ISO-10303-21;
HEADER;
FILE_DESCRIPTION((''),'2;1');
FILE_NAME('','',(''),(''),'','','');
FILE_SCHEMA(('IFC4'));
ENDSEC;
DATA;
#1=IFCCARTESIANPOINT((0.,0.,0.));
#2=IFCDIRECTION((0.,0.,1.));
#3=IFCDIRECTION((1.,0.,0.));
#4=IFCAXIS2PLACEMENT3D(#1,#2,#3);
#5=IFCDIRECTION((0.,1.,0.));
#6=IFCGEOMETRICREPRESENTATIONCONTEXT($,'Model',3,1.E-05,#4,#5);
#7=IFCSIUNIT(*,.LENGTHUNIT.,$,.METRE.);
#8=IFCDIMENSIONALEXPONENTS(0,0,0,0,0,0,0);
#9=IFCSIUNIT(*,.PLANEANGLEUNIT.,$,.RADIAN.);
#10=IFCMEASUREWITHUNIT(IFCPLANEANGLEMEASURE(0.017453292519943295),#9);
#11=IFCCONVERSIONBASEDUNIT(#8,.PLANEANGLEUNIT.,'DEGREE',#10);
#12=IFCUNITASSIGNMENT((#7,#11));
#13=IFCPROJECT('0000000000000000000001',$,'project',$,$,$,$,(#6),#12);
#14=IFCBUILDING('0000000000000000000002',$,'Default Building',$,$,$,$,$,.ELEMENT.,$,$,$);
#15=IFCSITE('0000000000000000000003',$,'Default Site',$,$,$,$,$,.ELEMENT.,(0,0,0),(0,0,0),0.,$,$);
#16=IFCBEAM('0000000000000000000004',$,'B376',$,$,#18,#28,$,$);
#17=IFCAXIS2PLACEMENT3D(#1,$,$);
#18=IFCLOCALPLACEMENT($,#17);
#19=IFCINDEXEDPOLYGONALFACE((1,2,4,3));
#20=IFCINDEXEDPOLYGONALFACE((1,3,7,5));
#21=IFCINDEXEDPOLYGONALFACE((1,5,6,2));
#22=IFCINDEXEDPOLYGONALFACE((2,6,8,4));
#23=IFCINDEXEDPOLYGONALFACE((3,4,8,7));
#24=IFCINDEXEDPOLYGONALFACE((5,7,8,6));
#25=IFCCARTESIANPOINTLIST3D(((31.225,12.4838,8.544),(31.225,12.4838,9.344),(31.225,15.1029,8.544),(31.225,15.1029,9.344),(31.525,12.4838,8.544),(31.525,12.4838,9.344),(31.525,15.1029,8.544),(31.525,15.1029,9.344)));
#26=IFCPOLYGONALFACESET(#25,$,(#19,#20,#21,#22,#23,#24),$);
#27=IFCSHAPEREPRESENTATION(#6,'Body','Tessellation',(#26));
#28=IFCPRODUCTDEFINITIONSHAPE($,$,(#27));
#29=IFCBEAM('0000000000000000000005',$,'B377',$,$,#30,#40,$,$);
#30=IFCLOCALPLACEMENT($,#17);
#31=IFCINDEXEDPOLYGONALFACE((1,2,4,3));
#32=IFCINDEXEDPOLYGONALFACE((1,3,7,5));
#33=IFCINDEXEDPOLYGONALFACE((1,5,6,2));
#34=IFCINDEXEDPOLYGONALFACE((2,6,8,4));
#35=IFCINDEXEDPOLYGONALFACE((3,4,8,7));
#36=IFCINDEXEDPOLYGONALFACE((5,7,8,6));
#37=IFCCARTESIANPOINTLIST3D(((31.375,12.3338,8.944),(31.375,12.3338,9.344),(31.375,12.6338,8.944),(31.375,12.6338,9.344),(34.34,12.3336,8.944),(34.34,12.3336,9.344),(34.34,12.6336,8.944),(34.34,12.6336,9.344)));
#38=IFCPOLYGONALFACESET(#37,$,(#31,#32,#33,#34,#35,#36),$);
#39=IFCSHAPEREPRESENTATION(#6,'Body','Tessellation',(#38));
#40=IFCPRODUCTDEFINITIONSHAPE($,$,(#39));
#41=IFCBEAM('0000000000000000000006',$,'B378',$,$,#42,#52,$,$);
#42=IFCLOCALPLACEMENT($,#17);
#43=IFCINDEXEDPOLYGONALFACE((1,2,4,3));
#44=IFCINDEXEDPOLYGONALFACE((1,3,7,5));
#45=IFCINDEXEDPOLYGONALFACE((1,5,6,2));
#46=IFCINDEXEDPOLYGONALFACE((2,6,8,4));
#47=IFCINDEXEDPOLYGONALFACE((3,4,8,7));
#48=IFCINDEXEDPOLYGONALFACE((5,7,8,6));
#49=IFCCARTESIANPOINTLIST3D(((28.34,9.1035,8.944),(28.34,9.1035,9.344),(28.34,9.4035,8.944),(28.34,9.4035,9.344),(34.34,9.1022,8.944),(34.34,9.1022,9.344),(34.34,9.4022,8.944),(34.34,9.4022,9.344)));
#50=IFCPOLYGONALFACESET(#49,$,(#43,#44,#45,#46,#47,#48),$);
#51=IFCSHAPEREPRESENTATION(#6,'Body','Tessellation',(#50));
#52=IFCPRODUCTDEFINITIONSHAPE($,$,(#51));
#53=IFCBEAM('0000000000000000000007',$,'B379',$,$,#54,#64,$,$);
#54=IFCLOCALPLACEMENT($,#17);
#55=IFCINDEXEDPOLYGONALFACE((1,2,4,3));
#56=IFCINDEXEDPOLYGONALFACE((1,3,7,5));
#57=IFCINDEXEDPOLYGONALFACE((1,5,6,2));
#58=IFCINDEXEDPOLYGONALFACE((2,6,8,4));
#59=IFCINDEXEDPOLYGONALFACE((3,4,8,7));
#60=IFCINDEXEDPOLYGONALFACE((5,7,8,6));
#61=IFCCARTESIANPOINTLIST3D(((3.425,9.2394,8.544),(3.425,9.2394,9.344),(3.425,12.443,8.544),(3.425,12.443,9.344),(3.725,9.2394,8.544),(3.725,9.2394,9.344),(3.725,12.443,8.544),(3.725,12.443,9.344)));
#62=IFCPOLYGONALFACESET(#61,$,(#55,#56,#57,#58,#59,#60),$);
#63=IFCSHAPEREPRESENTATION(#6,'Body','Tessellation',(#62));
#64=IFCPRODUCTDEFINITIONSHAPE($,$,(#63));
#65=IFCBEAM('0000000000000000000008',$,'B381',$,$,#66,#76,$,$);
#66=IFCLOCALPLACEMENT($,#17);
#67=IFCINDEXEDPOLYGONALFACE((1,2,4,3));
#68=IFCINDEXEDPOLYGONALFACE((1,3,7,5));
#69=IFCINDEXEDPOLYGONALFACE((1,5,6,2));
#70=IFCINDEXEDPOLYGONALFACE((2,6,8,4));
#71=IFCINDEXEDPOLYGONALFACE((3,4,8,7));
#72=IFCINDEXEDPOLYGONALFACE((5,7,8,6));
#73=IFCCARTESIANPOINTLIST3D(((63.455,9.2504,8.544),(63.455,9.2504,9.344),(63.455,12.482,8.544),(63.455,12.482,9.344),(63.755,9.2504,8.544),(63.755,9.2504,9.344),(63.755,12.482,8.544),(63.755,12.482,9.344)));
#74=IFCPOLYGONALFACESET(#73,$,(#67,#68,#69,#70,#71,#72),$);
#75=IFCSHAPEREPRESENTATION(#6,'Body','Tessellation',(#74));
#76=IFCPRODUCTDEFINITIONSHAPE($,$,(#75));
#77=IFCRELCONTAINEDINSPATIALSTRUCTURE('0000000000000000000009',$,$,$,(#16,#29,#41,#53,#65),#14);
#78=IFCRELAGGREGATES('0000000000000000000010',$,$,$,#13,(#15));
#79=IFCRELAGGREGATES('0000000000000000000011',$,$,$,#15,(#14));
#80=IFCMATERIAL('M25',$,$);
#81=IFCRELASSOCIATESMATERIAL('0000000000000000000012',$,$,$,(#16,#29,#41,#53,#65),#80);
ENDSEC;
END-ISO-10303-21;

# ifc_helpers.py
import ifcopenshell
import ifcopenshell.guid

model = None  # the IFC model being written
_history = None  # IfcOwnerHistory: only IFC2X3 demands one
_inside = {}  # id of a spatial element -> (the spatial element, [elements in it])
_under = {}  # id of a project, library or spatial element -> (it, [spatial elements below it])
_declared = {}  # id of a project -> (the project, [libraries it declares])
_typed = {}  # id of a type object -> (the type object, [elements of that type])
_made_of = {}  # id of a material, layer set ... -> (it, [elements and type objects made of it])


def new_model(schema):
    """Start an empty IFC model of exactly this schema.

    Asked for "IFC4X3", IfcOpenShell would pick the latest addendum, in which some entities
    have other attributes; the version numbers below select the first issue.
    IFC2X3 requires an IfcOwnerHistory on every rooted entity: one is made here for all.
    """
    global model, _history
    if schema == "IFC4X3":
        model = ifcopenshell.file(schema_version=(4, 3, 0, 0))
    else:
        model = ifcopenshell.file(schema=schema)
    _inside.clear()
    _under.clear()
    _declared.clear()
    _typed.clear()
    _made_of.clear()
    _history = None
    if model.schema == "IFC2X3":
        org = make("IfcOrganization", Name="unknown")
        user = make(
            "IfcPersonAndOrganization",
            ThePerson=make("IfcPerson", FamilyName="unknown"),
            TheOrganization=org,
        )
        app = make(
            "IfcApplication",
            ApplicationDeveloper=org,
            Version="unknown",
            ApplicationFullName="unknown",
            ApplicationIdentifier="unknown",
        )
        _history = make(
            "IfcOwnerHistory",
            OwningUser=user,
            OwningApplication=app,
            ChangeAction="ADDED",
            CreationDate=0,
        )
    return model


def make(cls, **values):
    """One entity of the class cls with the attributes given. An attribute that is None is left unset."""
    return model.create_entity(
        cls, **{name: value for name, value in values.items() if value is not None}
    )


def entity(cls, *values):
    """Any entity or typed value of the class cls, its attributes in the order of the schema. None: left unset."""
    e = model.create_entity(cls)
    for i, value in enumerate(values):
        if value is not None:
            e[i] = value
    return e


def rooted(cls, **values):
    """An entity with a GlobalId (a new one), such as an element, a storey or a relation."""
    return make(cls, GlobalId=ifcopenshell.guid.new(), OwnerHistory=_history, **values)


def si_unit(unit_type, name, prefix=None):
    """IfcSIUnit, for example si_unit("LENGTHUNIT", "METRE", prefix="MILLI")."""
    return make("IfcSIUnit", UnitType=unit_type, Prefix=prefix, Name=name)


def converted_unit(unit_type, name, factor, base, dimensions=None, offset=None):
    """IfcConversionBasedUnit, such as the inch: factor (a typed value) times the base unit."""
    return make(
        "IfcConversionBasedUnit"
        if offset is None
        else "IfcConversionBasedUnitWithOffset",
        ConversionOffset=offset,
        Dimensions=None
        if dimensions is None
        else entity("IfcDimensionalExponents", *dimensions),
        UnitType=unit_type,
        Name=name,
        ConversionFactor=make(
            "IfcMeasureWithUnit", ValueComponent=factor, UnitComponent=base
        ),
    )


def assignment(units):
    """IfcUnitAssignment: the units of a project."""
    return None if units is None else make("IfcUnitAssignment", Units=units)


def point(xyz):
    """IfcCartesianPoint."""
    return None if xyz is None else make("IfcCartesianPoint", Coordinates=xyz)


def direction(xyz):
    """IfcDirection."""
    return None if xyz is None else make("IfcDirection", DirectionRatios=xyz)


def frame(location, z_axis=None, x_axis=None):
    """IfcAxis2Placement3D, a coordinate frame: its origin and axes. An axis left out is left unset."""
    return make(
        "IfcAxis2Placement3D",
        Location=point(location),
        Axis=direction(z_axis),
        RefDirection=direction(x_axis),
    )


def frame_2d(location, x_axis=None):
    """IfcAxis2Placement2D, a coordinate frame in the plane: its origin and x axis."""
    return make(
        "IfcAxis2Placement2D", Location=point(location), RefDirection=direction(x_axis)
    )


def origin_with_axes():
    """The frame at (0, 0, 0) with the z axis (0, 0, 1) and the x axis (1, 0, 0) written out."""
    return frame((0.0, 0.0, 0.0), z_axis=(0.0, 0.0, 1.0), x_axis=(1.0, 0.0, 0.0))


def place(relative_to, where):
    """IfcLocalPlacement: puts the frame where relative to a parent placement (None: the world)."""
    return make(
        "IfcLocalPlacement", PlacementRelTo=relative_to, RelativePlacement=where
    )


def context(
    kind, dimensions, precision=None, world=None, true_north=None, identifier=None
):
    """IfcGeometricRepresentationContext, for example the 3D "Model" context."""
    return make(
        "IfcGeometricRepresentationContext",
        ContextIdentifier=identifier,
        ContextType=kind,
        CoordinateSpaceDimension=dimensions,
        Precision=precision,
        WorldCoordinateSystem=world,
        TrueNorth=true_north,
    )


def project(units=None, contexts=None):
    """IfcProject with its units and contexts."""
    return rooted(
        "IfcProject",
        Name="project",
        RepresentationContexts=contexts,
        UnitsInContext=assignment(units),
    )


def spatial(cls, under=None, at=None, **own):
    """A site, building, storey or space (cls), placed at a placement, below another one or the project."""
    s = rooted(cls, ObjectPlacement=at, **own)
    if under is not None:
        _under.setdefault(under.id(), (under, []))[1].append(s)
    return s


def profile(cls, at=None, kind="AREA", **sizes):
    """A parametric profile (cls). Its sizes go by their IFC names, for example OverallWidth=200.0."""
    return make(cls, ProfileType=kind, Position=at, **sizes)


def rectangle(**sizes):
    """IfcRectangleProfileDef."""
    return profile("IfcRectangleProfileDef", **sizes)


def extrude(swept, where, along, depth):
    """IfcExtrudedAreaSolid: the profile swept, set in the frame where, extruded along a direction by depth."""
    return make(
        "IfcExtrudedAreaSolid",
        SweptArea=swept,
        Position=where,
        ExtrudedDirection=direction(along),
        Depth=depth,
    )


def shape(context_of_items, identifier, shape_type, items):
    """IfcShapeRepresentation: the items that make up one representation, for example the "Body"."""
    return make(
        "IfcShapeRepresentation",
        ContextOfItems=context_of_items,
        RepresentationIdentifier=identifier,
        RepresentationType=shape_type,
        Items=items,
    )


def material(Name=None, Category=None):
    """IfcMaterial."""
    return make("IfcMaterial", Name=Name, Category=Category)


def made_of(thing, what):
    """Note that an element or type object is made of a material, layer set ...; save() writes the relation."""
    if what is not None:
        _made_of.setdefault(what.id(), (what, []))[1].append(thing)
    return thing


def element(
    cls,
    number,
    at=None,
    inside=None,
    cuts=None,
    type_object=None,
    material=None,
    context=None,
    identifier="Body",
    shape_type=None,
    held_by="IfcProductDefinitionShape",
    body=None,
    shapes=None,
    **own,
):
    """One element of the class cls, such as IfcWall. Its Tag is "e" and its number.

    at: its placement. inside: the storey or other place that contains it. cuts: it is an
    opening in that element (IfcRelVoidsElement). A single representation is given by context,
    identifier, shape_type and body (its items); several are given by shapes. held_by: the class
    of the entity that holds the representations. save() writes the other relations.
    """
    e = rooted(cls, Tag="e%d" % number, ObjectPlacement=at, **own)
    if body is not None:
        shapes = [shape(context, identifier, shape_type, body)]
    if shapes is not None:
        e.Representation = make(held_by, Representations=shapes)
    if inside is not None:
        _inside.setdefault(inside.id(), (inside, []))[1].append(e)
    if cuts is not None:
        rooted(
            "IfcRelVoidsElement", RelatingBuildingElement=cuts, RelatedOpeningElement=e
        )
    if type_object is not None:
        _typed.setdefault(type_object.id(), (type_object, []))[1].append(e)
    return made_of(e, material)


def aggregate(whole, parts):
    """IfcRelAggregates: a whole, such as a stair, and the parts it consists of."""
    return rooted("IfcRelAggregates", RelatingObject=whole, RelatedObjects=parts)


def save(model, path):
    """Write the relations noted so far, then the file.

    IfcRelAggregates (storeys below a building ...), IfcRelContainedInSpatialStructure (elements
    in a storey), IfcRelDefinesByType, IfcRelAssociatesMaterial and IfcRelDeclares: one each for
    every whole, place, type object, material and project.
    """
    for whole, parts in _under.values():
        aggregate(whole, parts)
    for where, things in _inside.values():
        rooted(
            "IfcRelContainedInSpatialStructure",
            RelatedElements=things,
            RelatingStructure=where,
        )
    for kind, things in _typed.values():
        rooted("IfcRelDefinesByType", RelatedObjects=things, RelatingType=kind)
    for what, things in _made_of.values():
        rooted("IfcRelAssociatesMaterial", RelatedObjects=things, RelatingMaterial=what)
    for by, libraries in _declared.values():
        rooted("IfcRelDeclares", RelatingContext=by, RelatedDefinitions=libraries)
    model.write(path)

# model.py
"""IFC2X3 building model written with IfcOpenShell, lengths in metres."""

from ifc_helpers import new_model, entity, si_unit, converted_unit, direction, frame, frame_2d, origin_with_axes, place, context, project, spatial, rectangle, extrude, material, element, save


model = new_model("IFC2X3")

# Units and contexts
model_context = context("Model", 3, precision=1e-05, world=origin_with_axes(), true_north=direction((0.0, 1.0, 0.0)))
ifc_project = project(units=[si_unit("LENGTHUNIT", "METRE"), converted_unit("PLANEANGLEUNIT", "DEGREE", entity("IfcPlaneAngleMeasure", 0.017453292519943295), si_unit("PLANEANGLEUNIT", "RADIAN"), dimensions=[0, 0, 0, 0, 0, 0, 0])], contexts=[model_context])

# Site, building
site = spatial("IfcSite", under=ifc_project, Name="Default Site", CompositionType="ELEMENT", RefLatitude=(0, 0, 0), RefLongitude=(0, 0, 0), RefElevation=0.0)
building = spatial("IfcBuilding", under=site, Name="Default Building", CompositionType="ELEMENT")

# Beams
ifc_material = material(Name="M25")
placement = place(None, origin_with_axes())
element("IfcBeam", 1, at=placement, inside=building, material=ifc_material, Name="B376", context=model_context, shape_type="SweptSolid", body=[
    extrude(rectangle(XDim=0.3, YDim=0.8, at=frame_2d((0.0, 0.0), x_axis=(0.0, 1.0, 0.0))), frame((31.375, 15.1029, 8.944), z_axis=(0.0, -1.0, 0.0), x_axis=(0.0, 0.0, -1.0)), (0.0, 0.0, 1.0), 2.6191),
])
element("IfcBeam", 2, at=placement, inside=building, material=ifc_material, Name="B377", context=model_context, shape_type="SweptSolid", body=[
    extrude(rectangle(XDim=0.3, YDim=0.4, at=frame_2d((0.0, 0.0), x_axis=(0.0, 1.0, 0.0))), frame((31.375, 12.4838, 9.144), z_axis=(1.0, -0.000067, 0.0), x_axis=(0.0, 0.0, -1.0)), (0.0, 0.0, 1.0), 2.965),
])
element("IfcBeam", 3, at=placement, inside=building, material=ifc_material, Name="B378", context=model_context, shape_type="SweptSolid", body=[
    extrude(rectangle(XDim=0.3, YDim=0.4, at=frame_2d((0.0, 0.0), x_axis=(0.0, 1.0, 0.0))), frame((28.34, 9.2535, 9.144), z_axis=(1.0, -0.000213, 0.0), x_axis=(0.0, 0.0, -1.0)), (0.0, 0.0, 1.0), 6.0),
])
element("IfcBeam", 4, at=placement, inside=building, material=ifc_material, Name="B379", context=model_context, shape_type="SweptSolid", body=[
    extrude(rectangle(XDim=0.3, YDim=0.8, at=frame_2d((0.0, 0.0), x_axis=(0.0, 1.0, 0.0))), frame((3.575, 12.443, 8.944), z_axis=(0.0, -1.0, 0.0), x_axis=(0.0, 0.0, -1.0)), (0.0, 0.0, 1.0), 3.2036),
])
element("IfcBeam", 5, at=placement, inside=building, material=ifc_material, Name="B381", context=model_context, shape_type="SweptSolid", body=[
    extrude(rectangle(XDim=0.3, YDim=0.8, at=frame_2d((0.0, 0.0), x_axis=(0.0, 1.0, 0.0))), frame((63.605, 12.482, 8.944), z_axis=(0.0, -1.0, 0.0), x_axis=(0.0, 0.0, -1.0)), (0.0, 0.0, 1.0), 3.2316),
])

save(model, "model.ifc")
